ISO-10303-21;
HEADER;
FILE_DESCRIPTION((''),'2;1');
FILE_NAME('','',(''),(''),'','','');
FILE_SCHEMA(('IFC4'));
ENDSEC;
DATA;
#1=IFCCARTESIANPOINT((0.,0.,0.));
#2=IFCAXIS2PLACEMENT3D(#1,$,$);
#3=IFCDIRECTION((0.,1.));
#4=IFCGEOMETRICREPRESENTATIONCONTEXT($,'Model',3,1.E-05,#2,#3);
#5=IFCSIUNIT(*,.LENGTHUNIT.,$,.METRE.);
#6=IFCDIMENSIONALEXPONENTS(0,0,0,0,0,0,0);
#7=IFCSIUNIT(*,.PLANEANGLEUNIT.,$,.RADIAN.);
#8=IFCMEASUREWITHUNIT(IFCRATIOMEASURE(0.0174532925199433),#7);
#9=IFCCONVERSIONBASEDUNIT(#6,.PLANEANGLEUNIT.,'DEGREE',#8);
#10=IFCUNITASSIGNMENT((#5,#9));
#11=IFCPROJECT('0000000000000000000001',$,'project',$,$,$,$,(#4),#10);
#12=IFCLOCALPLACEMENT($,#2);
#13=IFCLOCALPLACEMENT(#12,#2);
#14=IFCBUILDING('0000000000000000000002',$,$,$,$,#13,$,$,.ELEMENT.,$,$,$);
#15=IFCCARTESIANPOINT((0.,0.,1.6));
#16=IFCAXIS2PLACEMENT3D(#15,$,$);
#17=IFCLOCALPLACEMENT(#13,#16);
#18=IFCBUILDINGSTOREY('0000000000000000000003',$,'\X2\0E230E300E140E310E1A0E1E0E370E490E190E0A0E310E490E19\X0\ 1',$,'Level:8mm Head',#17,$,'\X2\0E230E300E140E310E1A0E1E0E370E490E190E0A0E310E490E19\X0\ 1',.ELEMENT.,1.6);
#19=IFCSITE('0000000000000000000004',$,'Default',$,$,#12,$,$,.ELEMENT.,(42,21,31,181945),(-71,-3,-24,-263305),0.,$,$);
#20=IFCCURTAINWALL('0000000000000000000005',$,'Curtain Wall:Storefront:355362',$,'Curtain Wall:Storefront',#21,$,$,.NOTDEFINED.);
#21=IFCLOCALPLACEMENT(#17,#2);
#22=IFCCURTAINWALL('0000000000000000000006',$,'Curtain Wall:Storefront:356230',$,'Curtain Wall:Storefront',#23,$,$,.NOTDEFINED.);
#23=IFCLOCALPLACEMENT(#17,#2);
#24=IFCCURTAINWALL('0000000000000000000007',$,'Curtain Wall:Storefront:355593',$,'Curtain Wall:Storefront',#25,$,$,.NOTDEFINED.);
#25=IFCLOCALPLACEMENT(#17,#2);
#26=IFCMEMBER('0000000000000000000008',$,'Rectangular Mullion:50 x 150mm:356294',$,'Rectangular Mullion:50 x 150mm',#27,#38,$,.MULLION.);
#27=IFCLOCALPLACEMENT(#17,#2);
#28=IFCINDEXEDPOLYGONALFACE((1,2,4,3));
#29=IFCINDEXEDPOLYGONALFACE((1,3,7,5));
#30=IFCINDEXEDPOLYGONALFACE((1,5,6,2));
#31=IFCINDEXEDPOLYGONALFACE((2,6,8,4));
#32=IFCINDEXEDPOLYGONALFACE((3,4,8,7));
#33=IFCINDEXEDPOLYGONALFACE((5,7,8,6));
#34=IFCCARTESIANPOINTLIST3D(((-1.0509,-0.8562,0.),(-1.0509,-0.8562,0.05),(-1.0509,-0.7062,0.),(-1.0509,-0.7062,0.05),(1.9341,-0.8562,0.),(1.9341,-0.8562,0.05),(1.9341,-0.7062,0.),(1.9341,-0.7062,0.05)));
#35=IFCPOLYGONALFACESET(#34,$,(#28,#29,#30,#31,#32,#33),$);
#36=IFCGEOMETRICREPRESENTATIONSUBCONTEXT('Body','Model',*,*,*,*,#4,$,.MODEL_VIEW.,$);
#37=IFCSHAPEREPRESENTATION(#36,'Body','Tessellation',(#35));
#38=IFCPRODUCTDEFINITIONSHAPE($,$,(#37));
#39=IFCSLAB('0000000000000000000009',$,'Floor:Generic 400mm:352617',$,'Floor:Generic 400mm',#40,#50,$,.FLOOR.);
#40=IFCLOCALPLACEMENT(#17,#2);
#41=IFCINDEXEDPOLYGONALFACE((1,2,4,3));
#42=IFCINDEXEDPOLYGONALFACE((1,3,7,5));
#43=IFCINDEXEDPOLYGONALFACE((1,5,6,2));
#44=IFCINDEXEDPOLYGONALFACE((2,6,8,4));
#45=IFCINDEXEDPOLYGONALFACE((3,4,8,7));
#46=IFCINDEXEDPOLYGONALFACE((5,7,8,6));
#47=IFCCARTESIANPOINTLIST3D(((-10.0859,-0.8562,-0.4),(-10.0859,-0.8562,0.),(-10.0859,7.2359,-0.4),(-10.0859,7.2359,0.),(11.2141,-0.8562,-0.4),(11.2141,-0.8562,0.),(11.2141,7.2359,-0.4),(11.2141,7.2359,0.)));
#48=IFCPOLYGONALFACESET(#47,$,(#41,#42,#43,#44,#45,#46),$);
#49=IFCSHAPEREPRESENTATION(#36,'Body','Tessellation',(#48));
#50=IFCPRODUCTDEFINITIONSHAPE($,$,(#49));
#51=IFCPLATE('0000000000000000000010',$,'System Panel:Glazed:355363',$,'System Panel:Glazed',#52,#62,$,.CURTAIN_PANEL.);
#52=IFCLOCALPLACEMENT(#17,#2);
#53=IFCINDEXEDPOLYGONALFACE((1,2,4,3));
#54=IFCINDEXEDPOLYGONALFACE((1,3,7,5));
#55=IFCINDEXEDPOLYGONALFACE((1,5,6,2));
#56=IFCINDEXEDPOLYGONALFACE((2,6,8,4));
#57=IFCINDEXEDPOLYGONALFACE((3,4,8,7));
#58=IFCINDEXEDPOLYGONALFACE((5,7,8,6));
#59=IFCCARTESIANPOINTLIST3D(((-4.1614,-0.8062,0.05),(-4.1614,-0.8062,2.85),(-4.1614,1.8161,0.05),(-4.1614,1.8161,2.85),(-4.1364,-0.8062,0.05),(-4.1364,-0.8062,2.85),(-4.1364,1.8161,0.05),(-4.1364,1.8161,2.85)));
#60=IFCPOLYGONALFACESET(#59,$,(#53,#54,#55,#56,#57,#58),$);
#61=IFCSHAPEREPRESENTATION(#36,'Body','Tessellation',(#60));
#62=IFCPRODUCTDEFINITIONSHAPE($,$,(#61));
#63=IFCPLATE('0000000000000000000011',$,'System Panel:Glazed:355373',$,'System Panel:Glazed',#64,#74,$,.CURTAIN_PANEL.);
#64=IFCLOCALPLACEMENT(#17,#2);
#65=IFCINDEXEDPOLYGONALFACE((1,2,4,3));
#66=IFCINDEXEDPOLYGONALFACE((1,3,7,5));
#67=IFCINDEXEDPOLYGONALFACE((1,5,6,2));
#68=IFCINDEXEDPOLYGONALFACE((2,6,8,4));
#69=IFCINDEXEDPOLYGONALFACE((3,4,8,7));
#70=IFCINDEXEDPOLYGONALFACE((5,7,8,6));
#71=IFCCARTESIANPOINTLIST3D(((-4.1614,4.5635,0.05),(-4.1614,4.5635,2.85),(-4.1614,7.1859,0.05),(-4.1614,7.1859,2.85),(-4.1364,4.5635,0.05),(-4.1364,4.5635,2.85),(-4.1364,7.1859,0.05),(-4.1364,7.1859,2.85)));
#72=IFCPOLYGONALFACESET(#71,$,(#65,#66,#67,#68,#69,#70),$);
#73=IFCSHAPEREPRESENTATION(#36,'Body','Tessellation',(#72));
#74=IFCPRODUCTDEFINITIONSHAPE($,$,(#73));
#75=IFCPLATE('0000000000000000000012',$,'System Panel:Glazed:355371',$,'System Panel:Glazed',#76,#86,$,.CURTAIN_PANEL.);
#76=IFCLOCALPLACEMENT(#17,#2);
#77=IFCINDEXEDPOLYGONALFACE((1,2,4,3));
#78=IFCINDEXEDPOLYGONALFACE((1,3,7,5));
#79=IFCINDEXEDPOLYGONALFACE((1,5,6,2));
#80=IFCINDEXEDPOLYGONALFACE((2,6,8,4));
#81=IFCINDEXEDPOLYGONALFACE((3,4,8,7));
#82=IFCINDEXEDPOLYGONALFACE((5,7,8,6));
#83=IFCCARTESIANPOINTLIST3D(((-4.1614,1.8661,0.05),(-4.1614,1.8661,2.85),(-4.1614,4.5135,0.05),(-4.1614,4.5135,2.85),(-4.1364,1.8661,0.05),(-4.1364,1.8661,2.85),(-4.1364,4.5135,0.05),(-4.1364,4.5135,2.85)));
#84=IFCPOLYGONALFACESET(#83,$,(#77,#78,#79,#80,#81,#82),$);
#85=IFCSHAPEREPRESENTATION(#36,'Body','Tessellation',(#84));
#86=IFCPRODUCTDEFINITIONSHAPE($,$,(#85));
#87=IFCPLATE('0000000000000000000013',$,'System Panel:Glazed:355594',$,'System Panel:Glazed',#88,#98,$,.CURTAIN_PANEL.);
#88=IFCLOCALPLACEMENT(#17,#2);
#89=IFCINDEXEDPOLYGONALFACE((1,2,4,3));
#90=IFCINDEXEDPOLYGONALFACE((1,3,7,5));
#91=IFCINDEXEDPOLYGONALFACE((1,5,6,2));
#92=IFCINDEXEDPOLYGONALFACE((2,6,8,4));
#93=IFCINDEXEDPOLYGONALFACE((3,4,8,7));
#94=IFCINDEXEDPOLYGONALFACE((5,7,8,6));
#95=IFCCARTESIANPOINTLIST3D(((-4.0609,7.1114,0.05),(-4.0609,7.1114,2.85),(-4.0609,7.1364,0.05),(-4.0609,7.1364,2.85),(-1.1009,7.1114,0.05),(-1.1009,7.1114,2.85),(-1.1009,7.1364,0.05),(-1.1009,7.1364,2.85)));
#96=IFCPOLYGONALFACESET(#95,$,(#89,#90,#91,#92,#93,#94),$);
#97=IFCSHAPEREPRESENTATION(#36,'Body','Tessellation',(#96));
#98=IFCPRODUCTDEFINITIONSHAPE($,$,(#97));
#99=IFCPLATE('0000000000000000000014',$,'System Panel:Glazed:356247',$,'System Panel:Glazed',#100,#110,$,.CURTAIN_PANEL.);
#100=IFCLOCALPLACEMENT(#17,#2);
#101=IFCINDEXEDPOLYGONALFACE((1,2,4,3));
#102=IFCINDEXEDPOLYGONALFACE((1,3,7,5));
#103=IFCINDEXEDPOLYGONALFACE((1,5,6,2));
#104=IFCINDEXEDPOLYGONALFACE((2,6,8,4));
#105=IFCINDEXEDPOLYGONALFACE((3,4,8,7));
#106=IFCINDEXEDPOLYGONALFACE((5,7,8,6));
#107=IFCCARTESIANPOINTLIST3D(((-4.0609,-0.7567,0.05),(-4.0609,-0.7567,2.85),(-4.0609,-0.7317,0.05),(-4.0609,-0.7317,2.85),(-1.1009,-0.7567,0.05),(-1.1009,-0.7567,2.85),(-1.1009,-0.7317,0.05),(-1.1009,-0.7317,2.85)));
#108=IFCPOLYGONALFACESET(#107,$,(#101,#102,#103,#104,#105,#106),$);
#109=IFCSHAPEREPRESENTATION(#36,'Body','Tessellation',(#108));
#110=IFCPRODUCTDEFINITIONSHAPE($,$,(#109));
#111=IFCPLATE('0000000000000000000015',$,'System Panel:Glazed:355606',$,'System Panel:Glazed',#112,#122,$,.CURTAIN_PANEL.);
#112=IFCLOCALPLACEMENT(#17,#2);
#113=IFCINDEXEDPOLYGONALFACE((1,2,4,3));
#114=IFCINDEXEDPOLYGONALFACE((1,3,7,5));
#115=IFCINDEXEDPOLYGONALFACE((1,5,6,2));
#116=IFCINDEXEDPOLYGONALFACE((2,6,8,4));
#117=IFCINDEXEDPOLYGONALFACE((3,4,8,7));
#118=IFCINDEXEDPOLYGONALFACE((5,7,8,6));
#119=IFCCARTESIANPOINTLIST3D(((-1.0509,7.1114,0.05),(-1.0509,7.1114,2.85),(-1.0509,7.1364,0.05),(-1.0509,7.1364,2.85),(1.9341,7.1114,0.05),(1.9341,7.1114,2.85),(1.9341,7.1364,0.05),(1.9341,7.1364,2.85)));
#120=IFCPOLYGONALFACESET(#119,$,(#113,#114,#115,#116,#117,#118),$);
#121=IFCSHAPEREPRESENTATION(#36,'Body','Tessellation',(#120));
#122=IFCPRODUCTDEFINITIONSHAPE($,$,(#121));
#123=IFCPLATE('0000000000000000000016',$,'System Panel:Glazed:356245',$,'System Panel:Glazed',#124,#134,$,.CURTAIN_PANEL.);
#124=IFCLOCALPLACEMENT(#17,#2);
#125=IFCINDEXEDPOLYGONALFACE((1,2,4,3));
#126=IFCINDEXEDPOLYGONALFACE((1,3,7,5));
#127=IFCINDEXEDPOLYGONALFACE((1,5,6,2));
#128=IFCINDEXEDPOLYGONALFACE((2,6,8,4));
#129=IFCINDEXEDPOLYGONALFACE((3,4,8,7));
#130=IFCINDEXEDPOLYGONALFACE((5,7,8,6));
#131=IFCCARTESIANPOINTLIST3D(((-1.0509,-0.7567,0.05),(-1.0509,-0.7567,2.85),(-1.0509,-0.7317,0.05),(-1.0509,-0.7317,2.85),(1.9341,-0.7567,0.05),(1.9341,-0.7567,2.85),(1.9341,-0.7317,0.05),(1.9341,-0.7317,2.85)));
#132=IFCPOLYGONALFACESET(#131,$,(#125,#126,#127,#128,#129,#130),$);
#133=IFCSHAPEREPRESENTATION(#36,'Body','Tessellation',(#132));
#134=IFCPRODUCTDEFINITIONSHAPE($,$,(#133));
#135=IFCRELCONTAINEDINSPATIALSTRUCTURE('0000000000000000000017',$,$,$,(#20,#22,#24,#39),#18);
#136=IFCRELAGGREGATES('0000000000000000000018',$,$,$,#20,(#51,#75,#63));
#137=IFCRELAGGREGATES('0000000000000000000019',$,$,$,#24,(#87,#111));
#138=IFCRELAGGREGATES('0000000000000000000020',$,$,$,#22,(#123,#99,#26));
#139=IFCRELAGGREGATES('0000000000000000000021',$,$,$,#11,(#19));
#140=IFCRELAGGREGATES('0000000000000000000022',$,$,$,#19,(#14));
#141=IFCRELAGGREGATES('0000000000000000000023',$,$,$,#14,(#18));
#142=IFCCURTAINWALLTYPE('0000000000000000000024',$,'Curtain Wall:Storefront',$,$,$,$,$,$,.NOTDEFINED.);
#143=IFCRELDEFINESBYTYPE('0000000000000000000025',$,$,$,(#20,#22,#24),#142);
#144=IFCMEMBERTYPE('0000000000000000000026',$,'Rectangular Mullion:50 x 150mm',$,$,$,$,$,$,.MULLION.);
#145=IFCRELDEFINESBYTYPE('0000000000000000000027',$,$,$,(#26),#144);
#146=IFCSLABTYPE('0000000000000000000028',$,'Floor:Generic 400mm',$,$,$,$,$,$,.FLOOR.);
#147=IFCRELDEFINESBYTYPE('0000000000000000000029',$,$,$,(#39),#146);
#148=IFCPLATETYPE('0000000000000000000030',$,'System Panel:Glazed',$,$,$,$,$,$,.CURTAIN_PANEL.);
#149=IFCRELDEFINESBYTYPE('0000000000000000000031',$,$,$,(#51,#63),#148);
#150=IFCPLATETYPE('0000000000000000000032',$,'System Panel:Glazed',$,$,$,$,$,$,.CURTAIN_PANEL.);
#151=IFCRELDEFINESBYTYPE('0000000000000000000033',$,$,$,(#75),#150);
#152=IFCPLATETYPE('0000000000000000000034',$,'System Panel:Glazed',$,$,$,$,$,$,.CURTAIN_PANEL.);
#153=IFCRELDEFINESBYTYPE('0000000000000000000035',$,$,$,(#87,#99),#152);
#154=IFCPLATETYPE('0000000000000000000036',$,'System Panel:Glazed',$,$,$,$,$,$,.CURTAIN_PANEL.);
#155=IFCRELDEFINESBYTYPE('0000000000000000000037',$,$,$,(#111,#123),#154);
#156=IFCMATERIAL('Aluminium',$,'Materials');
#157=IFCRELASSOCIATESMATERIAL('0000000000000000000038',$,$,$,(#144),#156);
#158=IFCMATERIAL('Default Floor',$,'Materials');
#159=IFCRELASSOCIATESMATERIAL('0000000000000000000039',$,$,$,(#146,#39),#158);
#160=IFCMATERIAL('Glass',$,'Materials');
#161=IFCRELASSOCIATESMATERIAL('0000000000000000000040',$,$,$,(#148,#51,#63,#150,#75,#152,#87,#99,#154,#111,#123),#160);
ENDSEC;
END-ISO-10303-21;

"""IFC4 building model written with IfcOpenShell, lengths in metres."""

from ifc_helpers import new_model, entity, si_unit, converted_unit, direction, frame, origin, place, context, subcontext, project, spatial, indexed_curve, outline, extrude, source, transform, mapped, material, type_object, type_shapes, element, aggregate, save


model = new_model("IFC4")

# Units and contexts
model_context = context("Model", 3, precision=1e-05, world=origin(), true_north=direction((0.0, 1.0)))
body_context = subcontext(model_context, "Body", "Model", "MODEL_VIEW")
ifc_project = project(units=[si_unit("LENGTHUNIT", "METRE"), converted_unit("PLANEANGLEUNIT", "DEGREE", entity("IfcRatioMeasure", 0.0174532925199433), si_unit("PLANEANGLEUNIT", "RADIAN"), dimensions=[0, 0, 0, 0, 0, 0, 0])], contexts=[model_context])

# Site, building, storey
site_placement = place(None, origin())
site = spatial("IfcSite", under=ifc_project, at=site_placement, Name="Default", CompositionType="ELEMENT", RefLatitude=(42, 21, 31, 181945), RefLongitude=(-71, -3, -24, -263305), RefElevation=0.0)
building_placement = place(site_placement, origin())
building = spatial("IfcBuilding", under=site, at=building_placement, CompositionType="ELEMENT")
storey_placement = place(building_placement, frame((0.0, 0.0, 1.6)))
storey = spatial("IfcBuildingStorey", under=building, at=storey_placement, Name="ระดับพื้นชั้น 1", ObjectType="Level:8mm Head", LongName="ระดับพื้นชั้น 1", CompositionType="ELEMENT", Elevation=1.6)

# Curtain wall
curtain_wall_type = type_object("IfcCurtainWallType", Name="Curtain Wall:Storefront", PredefinedType="NOTDEFINED")
curtain_wall_1_placement = place(storey_placement, frame((0.0, 0.0, -1.6)))
curtain_wall_1 = element("IfcCurtainWall", 1, at=curtain_wall_1_placement, inside=storey, type_object=curtain_wall_type, Name="Curtain Wall:Storefront:355362", ObjectType="Curtain Wall:Storefront", PredefinedType="NOTDEFINED")
ifc_material_1 = material(Name="Aluminium", Category="Materials")

# Curtain wall
curtain_wall_2_placement = place(storey_placement, frame((0.0, 0.0, -1.6)))
curtain_wall_2 = element("IfcCurtainWall", 2, at=curtain_wall_2_placement, inside=storey, type_object=curtain_wall_type, Name="Curtain Wall:Storefront:356230", ObjectType="Curtain Wall:Storefront", PredefinedType="NOTDEFINED")

# Curtain wall
curtain_wall_3_placement = place(storey_placement, frame((0.0, 0.0, -1.6)))
curtain_wall_3 = element("IfcCurtainWall", 3, at=curtain_wall_3_placement, inside=storey, type_object=curtain_wall_type, Name="Curtain Wall:Storefront:355593", ObjectType="Curtain Wall:Storefront", PredefinedType="NOTDEFINED")

# Member
member_type_1 = type_object("IfcMemberType", Name="Rectangular Mullion:50 x 150mm", PredefinedType="MULLION", material=ifc_material_1)
shared_shape_1 = source(origin(), body_context, "Body", "SweptSolid", [
    extrude(outline(indexed_curve([(-0.075, -0.025), (0.075, -0.025), (0.075, 0.025), (-0.075, 0.025), (-0.075, -0.025)], self_intersect=False)), frame((-0.025, 0.0, -2.985), z_axis=(0.0, 0.0, 1.0), x_axis=(0.0, -1.0, 0.0)), (0.0, 0.0, 1.0), 2.985),
])
type_shapes(member_type_1, [shared_shape_1])
member_1_placement = place(curtain_wall_2_placement, frame((1.9341, -0.7812, 1.6), z_axis=(1.0, 0.0, 0.0), x_axis=(0.0, 0.0, -1.0)))
member_1 = element("IfcMember", 4, at=member_1_placement, type_object=member_type_1, Name="Rectangular Mullion:50 x 150mm:356294", ObjectType="Rectangular Mullion:50 x 150mm", PredefinedType="MULLION", context=body_context, shape_type="MappedRepresentation", body=[
    mapped(shared_shape_1, transform((0.0, 0.0, 0.0), scale=1.0)),
])

# Slab
ifc_material_2 = material(Name="Default Floor", Category="Materials")
slab_type = type_object("IfcSlabType", Name="Floor:Generic 400mm", PredefinedType="FLOOR", material=ifc_material_2)
slab_placement = place(storey_placement, origin())
element("IfcSlab", 5, at=slab_placement, inside=storey, type_object=slab_type, material=ifc_material_2, Name="Floor:Generic 400mm:352617", ObjectType="Floor:Generic 400mm", PredefinedType="FLOOR", context=body_context, shape_type="SweptSolid", body=[
    extrude(outline(indexed_curve([(-4.046, -10.65), (4.0461, -10.65), (4.046, 10.65), (-4.0461, 10.65), (-4.046, -10.65)], self_intersect=False)), frame((0.5641, 3.1898, 0.0), z_axis=(0.0, 0.0, -1.0), x_axis=(0.0, 1.0, 0.0)), (0.0, 0.0, 1.0), 0.4),
])

# Plates
ifc_material_3 = material(Name="Glass", Category="Materials")
plate_type_1 = type_object("IfcPlateType", Name="System Panel:Glazed", PredefinedType="CURTAIN_PANEL", material=ifc_material_3)
shared_shape_2 = source(origin(), body_context, "Body", "SweptSolid", [
    extrude(outline(indexed_curve([(-0.0125, -1.3112), (0.0125, -1.3112), (0.0125, 1.3112), (-0.0125, 1.3112), (-0.0125, -1.3112)], self_intersect=False)), frame((0.0, -0.037, 0.0), z_axis=(0.0, 0.0, 1.0), x_axis=(0.0, 1.0, 0.0)), (0.0, 0.0, 1.0), 2.8),
])
type_shapes(plate_type_1, [shared_shape_2])
plate_1_placement = place(curtain_wall_1_placement, frame((-4.1859, 0.5049, 1.65), z_axis=(0.0, 0.0, 1.0), x_axis=(0.0, 1.0, 0.0)))
plate_1 = element("IfcPlate", 6, at=plate_1_placement, type_object=plate_type_1, material=ifc_material_3, Name="System Panel:Glazed:355363", ObjectType="System Panel:Glazed", PredefinedType="CURTAIN_PANEL", context=body_context, shape_type="MappedRepresentation", body=[
    mapped(shared_shape_2, transform((0.0, 0.0, 0.0), scale=1.0)),
])
plate_2_placement = place(curtain_wall_1_placement, frame((-4.1859, 5.8747, 1.65), z_axis=(0.0, 0.0, 1.0), x_axis=(0.0, 1.0, 0.0)))
plate_2 = element("IfcPlate", 7, at=plate_2_placement, type_object=plate_type_1, material=ifc_material_3, Name="System Panel:Glazed:355373", ObjectType="System Panel:Glazed", PredefinedType="CURTAIN_PANEL", context=body_context, shape_type="MappedRepresentation", body=[
    mapped(shared_shape_2, transform((0.0, 0.0, 0.0), scale=1.0)),
])
plate_type_2 = type_object("IfcPlateType", Name="System Panel:Glazed", PredefinedType="CURTAIN_PANEL", material=ifc_material_3)
shared_shape_3 = source(origin(), body_context, "Body", "SweptSolid", [
    extrude(outline(indexed_curve([(-0.0125, -1.3237), (0.0125, -1.3237), (0.0125, 1.3237), (-0.0125, 1.3237), (-0.0125, -1.3237)], self_intersect=False)), frame((0.0, -0.037, 0.0), z_axis=(0.0, 0.0, 1.0), x_axis=(0.0, 1.0, 0.0)), (0.0, 0.0, 1.0), 2.8),
])
type_shapes(plate_type_2, [shared_shape_3])
plate_3_placement = place(curtain_wall_1_placement, frame((-4.1859, 3.1898, 1.65), z_axis=(0.0, 0.0, 1.0), x_axis=(0.0, 1.0, 0.0)))
plate_3 = element("IfcPlate", 8, at=plate_3_placement, type_object=plate_type_2, material=ifc_material_3, Name="System Panel:Glazed:355371", ObjectType="System Panel:Glazed", PredefinedType="CURTAIN_PANEL", context=body_context, shape_type="MappedRepresentation", body=[
    mapped(shared_shape_3, transform((0.0, 0.0, 0.0), scale=1.0)),
])
aggregate(curtain_wall_1, [plate_1, plate_3, plate_2])
plate_type_3 = type_object("IfcPlateType", Name="System Panel:Glazed", PredefinedType="CURTAIN_PANEL", material=ifc_material_3)
shared_shape_4 = source(origin(), body_context, "Body", "SweptSolid", [
    extrude(outline(indexed_curve([(-0.0125, -1.48), (0.0125, -1.48), (0.0125, 1.48), (-0.0125, 1.48), (-0.0125, -1.48)], self_intersect=False)), frame((0.0, -0.037, 0.0), z_axis=(0.0, 0.0, 1.0), x_axis=(0.0, 1.0, 0.0)), (0.0, 0.0, 1.0), 2.8),
])
type_shapes(plate_type_3, [shared_shape_4])
plate_4_placement = place(curtain_wall_3_placement, frame((-2.5809, 7.1609, 1.65)))
plate_4 = element("IfcPlate", 9, at=plate_4_placement, type_object=plate_type_3, material=ifc_material_3, Name="System Panel:Glazed:355594", ObjectType="System Panel:Glazed", PredefinedType="CURTAIN_PANEL", context=body_context, shape_type="MappedRepresentation", body=[
    mapped(shared_shape_4, transform((0.0, 0.0, 0.0), scale=1.0)),
])
plate_5_placement = place(curtain_wall_2_placement, frame((-2.5809, -0.7812, 1.65), z_axis=(0.0, 0.0, 1.0), x_axis=(-1.0, 0.0, 0.0)))
plate_5 = element("IfcPlate", 10, at=plate_5_placement, type_object=plate_type_3, material=ifc_material_3, Name="System Panel:Glazed:356247", ObjectType="System Panel:Glazed", PredefinedType="CURTAIN_PANEL", context=body_context, shape_type="MappedRepresentation", body=[
    mapped(shared_shape_4, transform((0.0, 0.0, 0.0), scale=1.0)),
])
plate_type_4 = type_object("IfcPlateType", Name="System Panel:Glazed", PredefinedType="CURTAIN_PANEL", material=ifc_material_3)
shared_shape_5 = source(origin(), body_context, "Body", "SweptSolid", [
    extrude(outline(indexed_curve([(-0.0125, -1.4925), (0.0125, -1.4925), (0.0125, 1.4925), (-0.0125, 1.4925), (-0.0125, -1.4925)], self_intersect=False)), frame((0.0, -0.037, 0.0), z_axis=(0.0, 0.0, 1.0), x_axis=(0.0, 1.0, 0.0)), (0.0, 0.0, 1.0), 2.8),
])
type_shapes(plate_type_4, [shared_shape_5])
plate_6_placement = place(curtain_wall_3_placement, frame((0.4416, 7.1609, 1.65)))
plate_6 = element("IfcPlate", 11, at=plate_6_placement, type_object=plate_type_4, material=ifc_material_3, Name="System Panel:Glazed:355606", ObjectType="System Panel:Glazed", PredefinedType="CURTAIN_PANEL", context=body_context, shape_type="MappedRepresentation", body=[
    mapped(shared_shape_5, transform((0.0, 0.0, 0.0), scale=1.0)),
])
aggregate(curtain_wall_3, [plate_4, plate_6])
plate_7_placement = place(curtain_wall_2_placement, frame((0.4416, -0.7812, 1.65), z_axis=(0.0, 0.0, 1.0), x_axis=(-1.0, 0.0, 0.0)))
plate_7 = element("IfcPlate", 12, at=plate_7_placement, type_object=plate_type_4, material=ifc_material_3, Name="System Panel:Glazed:356245", ObjectType="System Panel:Glazed", PredefinedType="CURTAIN_PANEL", context=body_context, shape_type="MappedRepresentation", body=[
    mapped(shared_shape_5, transform((0.0, 0.0, 0.0), scale=1.0)),
])
aggregate(curtain_wall_2, [plate_7, plate_5, member_1])

save(model, "model.ifc")
